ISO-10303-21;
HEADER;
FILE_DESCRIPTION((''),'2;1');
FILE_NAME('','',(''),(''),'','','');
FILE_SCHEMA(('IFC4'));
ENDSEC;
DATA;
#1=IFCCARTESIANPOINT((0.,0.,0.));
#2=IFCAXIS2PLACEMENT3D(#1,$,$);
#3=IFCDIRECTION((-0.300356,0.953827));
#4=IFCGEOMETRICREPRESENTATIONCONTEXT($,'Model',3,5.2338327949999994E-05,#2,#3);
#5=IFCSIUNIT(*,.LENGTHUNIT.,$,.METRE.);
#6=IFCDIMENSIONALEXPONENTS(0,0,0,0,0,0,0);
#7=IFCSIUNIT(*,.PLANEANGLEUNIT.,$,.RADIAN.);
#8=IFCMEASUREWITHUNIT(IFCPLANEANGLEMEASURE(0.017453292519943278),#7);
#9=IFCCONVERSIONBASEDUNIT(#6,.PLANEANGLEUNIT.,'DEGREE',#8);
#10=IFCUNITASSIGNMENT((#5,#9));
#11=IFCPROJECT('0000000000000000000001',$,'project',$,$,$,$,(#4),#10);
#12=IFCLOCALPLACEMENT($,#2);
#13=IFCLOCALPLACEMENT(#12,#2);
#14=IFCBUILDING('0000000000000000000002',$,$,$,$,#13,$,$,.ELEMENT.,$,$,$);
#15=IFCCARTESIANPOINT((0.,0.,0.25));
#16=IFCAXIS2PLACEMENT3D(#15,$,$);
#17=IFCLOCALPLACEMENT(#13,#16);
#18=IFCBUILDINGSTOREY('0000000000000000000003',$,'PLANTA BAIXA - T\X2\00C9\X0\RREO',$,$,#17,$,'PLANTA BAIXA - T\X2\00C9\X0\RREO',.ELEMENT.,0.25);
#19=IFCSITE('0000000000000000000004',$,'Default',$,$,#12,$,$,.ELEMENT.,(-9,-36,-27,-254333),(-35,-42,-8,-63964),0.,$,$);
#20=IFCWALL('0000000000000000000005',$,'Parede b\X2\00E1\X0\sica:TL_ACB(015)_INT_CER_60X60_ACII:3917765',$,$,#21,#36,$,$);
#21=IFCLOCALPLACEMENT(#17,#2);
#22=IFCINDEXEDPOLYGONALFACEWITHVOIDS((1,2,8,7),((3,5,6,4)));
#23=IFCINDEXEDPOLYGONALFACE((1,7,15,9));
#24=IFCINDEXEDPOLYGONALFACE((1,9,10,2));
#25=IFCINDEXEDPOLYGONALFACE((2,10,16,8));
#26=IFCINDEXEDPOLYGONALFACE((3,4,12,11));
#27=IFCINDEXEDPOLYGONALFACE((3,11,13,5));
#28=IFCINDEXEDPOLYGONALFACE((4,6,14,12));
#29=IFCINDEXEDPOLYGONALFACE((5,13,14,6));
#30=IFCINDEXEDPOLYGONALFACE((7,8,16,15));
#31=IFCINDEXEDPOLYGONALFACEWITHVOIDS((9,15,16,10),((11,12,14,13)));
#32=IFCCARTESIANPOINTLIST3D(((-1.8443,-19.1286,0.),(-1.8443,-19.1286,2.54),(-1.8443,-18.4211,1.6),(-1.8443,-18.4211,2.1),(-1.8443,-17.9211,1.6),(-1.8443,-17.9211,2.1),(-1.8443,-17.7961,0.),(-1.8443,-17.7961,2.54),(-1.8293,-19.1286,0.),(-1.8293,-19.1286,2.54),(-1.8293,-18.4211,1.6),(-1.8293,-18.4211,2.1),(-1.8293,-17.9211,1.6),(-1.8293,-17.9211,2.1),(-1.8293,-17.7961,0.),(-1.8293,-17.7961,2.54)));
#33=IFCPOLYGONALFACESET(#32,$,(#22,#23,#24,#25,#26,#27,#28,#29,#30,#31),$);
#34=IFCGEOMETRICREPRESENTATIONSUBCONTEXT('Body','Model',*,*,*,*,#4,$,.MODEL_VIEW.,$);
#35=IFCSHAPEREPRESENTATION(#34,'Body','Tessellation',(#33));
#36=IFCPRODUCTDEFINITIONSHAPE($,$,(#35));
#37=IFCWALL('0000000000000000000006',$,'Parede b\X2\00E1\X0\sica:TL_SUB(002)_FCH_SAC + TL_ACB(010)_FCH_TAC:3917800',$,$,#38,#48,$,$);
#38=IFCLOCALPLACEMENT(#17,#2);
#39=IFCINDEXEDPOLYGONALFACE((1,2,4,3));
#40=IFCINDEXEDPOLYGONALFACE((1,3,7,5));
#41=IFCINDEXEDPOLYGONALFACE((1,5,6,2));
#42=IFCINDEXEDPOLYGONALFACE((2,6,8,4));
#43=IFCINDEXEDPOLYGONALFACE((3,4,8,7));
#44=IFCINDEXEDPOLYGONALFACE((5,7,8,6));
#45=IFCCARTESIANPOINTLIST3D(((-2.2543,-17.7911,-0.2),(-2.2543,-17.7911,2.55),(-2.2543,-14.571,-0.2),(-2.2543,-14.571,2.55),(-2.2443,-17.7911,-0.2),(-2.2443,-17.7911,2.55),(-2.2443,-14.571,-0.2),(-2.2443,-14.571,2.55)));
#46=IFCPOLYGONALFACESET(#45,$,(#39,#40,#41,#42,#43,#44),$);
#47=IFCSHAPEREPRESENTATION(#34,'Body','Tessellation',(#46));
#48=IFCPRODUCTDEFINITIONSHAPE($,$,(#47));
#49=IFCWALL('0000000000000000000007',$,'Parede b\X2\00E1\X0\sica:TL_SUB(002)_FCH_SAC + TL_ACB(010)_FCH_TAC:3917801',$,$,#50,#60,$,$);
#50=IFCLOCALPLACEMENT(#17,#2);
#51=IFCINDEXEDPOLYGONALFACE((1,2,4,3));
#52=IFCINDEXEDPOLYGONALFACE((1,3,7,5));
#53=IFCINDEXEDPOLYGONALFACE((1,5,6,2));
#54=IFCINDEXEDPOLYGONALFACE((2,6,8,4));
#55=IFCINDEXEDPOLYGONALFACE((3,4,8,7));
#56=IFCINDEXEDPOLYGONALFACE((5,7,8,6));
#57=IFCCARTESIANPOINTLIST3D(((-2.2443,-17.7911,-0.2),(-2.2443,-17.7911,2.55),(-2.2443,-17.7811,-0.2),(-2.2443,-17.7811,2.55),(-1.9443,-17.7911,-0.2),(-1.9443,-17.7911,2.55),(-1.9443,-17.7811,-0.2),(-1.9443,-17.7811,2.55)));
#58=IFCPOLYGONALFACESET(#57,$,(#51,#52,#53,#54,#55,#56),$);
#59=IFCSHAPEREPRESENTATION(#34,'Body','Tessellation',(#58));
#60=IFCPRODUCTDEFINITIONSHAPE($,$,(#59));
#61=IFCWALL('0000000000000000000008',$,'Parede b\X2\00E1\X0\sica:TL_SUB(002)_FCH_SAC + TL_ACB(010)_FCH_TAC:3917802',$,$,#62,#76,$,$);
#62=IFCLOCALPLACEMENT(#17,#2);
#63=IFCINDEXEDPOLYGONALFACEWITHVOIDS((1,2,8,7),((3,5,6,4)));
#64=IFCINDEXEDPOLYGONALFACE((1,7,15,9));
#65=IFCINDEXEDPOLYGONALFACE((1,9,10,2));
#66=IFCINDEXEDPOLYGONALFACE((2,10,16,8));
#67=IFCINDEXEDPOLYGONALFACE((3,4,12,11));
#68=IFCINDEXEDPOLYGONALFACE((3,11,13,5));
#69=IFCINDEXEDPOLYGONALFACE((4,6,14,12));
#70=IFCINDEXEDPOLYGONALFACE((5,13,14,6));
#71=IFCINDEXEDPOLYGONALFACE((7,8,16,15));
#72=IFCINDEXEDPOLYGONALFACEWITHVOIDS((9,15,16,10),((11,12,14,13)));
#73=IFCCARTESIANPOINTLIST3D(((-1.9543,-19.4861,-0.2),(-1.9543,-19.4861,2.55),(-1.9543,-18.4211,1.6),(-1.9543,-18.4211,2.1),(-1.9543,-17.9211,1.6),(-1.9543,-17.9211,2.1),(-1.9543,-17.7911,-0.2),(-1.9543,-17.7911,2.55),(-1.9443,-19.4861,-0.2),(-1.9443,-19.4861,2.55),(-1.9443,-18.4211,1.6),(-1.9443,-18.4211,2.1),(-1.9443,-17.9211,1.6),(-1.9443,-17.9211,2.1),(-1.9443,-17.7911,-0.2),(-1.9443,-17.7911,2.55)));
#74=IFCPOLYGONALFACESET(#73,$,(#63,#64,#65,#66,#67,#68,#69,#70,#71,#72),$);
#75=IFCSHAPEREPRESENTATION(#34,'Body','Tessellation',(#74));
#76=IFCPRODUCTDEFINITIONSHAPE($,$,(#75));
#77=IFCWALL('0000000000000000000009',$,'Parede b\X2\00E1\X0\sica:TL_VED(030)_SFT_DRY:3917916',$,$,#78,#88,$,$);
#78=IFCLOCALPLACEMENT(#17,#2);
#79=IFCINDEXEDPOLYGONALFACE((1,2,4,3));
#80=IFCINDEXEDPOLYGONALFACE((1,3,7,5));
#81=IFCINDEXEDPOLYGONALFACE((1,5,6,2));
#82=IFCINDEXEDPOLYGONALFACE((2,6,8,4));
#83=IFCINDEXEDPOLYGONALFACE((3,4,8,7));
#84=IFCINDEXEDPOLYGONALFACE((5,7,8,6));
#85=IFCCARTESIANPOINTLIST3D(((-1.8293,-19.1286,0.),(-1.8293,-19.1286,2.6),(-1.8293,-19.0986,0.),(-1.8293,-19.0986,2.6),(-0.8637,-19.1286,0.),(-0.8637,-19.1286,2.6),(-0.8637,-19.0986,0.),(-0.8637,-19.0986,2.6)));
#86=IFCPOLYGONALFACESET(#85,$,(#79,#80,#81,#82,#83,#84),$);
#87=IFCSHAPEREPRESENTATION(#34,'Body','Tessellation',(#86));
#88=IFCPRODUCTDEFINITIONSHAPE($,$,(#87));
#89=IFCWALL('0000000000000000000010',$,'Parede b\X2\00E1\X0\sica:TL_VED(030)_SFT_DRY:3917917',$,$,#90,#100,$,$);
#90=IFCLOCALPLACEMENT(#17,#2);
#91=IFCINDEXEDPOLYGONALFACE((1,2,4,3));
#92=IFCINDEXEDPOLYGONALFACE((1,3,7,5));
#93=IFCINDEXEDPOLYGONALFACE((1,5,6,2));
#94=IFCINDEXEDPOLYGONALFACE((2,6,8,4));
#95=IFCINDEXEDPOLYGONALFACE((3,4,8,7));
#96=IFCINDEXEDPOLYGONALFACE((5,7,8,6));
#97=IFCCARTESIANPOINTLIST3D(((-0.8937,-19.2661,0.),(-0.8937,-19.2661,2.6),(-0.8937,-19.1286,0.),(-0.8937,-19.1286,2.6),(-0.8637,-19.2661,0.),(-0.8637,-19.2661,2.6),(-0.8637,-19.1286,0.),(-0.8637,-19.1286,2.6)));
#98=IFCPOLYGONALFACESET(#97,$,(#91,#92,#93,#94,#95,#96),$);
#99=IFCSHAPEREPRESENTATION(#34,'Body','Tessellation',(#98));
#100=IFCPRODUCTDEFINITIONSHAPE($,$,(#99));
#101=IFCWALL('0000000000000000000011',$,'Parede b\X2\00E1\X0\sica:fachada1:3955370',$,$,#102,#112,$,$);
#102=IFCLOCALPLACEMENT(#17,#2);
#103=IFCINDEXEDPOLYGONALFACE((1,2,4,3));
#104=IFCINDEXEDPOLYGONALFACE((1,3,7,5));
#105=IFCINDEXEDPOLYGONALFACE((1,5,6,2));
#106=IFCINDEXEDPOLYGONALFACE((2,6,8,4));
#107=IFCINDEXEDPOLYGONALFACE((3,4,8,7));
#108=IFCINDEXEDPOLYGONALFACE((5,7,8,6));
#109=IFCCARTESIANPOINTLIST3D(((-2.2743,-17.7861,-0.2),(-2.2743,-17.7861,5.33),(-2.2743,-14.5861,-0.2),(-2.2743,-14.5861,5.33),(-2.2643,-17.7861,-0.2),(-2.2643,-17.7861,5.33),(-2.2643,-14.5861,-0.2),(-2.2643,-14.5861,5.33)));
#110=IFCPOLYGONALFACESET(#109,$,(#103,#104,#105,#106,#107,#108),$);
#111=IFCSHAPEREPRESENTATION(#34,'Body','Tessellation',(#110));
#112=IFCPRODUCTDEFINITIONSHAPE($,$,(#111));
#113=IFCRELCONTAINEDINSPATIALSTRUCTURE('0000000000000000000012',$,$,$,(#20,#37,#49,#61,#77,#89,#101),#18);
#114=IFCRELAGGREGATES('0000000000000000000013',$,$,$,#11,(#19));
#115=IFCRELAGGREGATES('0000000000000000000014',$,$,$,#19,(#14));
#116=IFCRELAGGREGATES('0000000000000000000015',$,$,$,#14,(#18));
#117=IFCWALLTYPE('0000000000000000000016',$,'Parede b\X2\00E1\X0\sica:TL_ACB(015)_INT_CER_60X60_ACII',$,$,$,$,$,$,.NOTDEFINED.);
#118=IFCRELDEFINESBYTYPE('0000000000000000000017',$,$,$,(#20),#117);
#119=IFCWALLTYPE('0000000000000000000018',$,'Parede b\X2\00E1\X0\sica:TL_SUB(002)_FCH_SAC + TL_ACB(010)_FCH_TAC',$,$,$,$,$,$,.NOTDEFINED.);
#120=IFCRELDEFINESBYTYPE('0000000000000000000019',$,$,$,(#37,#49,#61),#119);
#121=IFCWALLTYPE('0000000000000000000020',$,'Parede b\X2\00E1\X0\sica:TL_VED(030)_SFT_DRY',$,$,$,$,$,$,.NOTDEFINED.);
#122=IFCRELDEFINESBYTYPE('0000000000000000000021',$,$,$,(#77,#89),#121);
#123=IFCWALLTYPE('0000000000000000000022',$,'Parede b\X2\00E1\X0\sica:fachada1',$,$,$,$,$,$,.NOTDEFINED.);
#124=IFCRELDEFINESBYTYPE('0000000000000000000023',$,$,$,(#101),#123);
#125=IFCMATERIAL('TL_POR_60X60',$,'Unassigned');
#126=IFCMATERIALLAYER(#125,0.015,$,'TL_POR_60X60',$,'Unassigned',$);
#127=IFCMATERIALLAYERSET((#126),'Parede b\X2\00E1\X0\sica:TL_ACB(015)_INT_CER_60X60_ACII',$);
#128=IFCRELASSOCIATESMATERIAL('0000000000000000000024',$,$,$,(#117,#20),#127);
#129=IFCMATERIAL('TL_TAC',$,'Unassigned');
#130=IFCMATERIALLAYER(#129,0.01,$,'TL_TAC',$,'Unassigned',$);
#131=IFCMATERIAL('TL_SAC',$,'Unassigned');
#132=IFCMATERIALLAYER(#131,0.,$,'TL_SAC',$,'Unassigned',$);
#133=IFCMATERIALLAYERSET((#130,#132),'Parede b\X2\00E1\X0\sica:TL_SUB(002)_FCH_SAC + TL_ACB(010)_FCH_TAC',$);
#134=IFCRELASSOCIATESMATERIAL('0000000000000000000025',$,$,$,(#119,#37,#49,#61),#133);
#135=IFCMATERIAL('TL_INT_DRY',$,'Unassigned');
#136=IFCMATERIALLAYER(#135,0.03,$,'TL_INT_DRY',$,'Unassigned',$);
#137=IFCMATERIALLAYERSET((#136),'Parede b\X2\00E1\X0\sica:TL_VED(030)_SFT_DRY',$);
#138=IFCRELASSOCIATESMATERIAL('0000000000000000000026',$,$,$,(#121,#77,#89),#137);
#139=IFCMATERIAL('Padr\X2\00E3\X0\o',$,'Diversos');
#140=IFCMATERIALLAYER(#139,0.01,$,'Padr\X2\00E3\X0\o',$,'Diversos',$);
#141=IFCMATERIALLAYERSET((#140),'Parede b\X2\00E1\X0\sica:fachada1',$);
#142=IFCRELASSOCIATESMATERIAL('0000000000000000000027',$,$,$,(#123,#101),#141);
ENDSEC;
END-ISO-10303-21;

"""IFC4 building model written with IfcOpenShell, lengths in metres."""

from ifc_helpers import new_model, entity, si_unit, converted_unit, direction, frame, frame_2d, origin, place, context, subcontext, project, spatial, rectangle, extrude, material, layer, layer_set, layer_usage, type_object, element, save


model = new_model("IFC4")

# Units and contexts
model_context = context("Model", 3, precision=5.2338327949999994e-05, world=origin(), true_north=direction((-0.300356, 0.953827)))
body_context = subcontext(model_context, "Body", "Model", "MODEL_VIEW")
ifc_project = project(units=[si_unit("LENGTHUNIT", "METRE"), converted_unit("PLANEANGLEUNIT", "DEGREE", entity("IfcPlaneAngleMeasure", 0.017453292519943278), si_unit("PLANEANGLEUNIT", "RADIAN"), dimensions=[0, 0, 0, 0, 0, 0, 0])], contexts=[model_context])

# Site, building, storey
site_placement = place(None, origin())
site = spatial("IfcSite", under=ifc_project, at=site_placement, Name="Default", CompositionType="ELEMENT", RefLatitude=(-9, -36, -27, -254333), RefLongitude=(-35, -42, -8, -63964), RefElevation=0.0)
building_placement = place(site_placement, origin())
building = spatial("IfcBuilding", under=site, at=building_placement, CompositionType="ELEMENT")
storey_placement = place(building_placement, frame((0.0, 0.0, 0.25)))
storey = spatial("IfcBuildingStorey", under=building, at=storey_placement, Name="PLANTA BAIXA - TÉRREO", LongName="PLANTA BAIXA - TÉRREO", CompositionType="ELEMENT", Elevation=0.25)

# Shared definitions
ifc_material_1 = material(Name="TL_POR_60X60", Category="Unassigned")

# Shared definitions
ifc_material_2 = material(Name="TL_SAC", Category="Unassigned")

# Shared definitions
ifc_layer_1 = layer(ifc_material_1, 0.015, Name="TL_POR_60X60", Category="Unassigned")
ifc_layer_set_1 = layer_set([ifc_layer_1], Name="Parede básica:TL_ACB(015)_INT_CER_60X60_ACII")
wall_type_1 = type_object("IfcWallType", Name="Parede básica:TL_ACB(015)_INT_CER_60X60_ACII", PredefinedType="NOTDEFINED", material=ifc_layer_set_1)

# Wall, opening
ifc_layer_usage_1 = layer_usage(ifc_layer_set_1, "AXIS2", "NEGATIVE", 0.0075)
wall_1_placement = place(storey_placement, frame((-1.8368, -17.7961, 0.0), z_axis=(0.0, 0.0, 1.0), x_axis=(0.0, -1.0, 0.0)))
wall_1 = element("IfcWall", 1, at=wall_1_placement, inside=storey, type_object=wall_type_1, material=ifc_layer_usage_1, Name="Parede básica:TL_ACB(015)_INT_CER_60X60_ACII:3917765", context=body_context, shape_type="SweptSolid", body=[
    extrude(rectangle(XDim=1.3325, YDim=0.015, at=frame_2d((0.6662, 0.0), x_axis=(-1.0, 0.0))), origin(), (0.0, 0.0, 1.0), 2.54),
])
opening_1_placement = place(wall_1_placement, frame((-17.7961, 1.8368, 1.6)))
element("IfcOpeningElement", 2, at=opening_1_placement, cuts=wall_1, PredefinedType="OPENING", context=body_context, shape_type="SweptSolid", body=[
    extrude(rectangle(XDim=0.5, YDim=0.5, at=frame_2d((0.0, 0.0), x_axis=(1.0, 0.0))), frame((18.1711, -3.4683, 0.25), z_axis=(0.0, 1.0, 0.0), x_axis=(0.0, 0.0, 1.0)), (0.0, 0.0, 1.0), 3.048),
])

# Walls
ifc_material_3 = material(Name="TL_TAC", Category="Unassigned")
ifc_layer_2 = layer(ifc_material_3, 0.01, Name="TL_TAC", Category="Unassigned")
ifc_layer_3 = layer(ifc_material_2, 0.0, Name="TL_SAC", Category="Unassigned")
ifc_layer_set_2 = layer_set([ifc_layer_2, ifc_layer_3], Name="Parede básica:TL_SUB(002)_FCH_SAC + TL_ACB(010)_FCH_TAC")
ifc_layer_usage_2 = layer_usage(ifc_layer_set_2, "AXIS2", "NEGATIVE", 0.005)
wall_type_2 = type_object("IfcWallType", Name="Parede básica:TL_SUB(002)_FCH_SAC + TL_ACB(010)_FCH_TAC", PredefinedType="NOTDEFINED", material=ifc_layer_set_2)
wall_2_placement = place(storey_placement, frame((-2.2493, -14.571, -0.2), z_axis=(0.0, 0.0, 1.0), x_axis=(0.0, -1.0, 0.0)))
element("IfcWall", 3, at=wall_2_placement, inside=storey, type_object=wall_type_2, material=ifc_layer_usage_2, Name="Parede básica:TL_SUB(002)_FCH_SAC + TL_ACB(010)_FCH_TAC:3917800", context=body_context, shape_type="SweptSolid", body=[
    extrude(rectangle(XDim=3.2201, YDim=0.01, at=frame_2d((1.6101, 0.0), x_axis=(-1.0, 0.0))), origin(), (0.0, 0.0, 1.0), 2.75),
])
ifc_layer_usage_3 = layer_usage(ifc_layer_set_2, "AXIS2", "NEGATIVE", 0.005)
wall_3_placement = place(storey_placement, frame((-2.2443, -17.7861, -0.2)))
element("IfcWall", 4, at=wall_3_placement, inside=storey, type_object=wall_type_2, material=ifc_layer_usage_3, Name="Parede básica:TL_SUB(002)_FCH_SAC + TL_ACB(010)_FCH_TAC:3917801", context=body_context, shape_type="SweptSolid", body=[
    extrude(rectangle(XDim=0.3, YDim=0.01, at=frame_2d((0.15, 0.0), x_axis=(-1.0, 0.0))), origin(), (0.0, 0.0, 1.0), 2.75),
])

# Wall, opening
ifc_layer_usage_4 = layer_usage(ifc_layer_set_2, "AXIS2", "NEGATIVE", 0.005)
wall_4_placement = place(storey_placement, frame((-1.9493, -17.7911, -0.2), z_axis=(0.0, 0.0, 1.0), x_axis=(0.0, -1.0, 0.0)))
wall_4 = element("IfcWall", 5, at=wall_4_placement, inside=storey, type_object=wall_type_2, material=ifc_layer_usage_4, Name="Parede básica:TL_SUB(002)_FCH_SAC + TL_ACB(010)_FCH_TAC:3917802", context=body_context, shape_type="SweptSolid", body=[
    extrude(rectangle(XDim=1.695, YDim=0.01, at=frame_2d((0.8475, 0.0), x_axis=(-1.0, 0.0))), origin(), (0.0, 0.0, 1.0), 2.75),
])
opening_2_placement = place(wall_4_placement, frame((-17.7911, 1.9493, 1.8)))
element("IfcOpeningElement", 6, at=opening_2_placement, cuts=wall_4, PredefinedType="OPENING", context=body_context, shape_type="SweptSolid", body=[
    extrude(rectangle(XDim=0.5, YDim=0.5, at=frame_2d((0.0, 0.0), x_axis=(1.0, 0.0))), frame((18.1711, -3.4683, 0.25), z_axis=(0.0, 1.0, 0.0), x_axis=(0.0, 0.0, 1.0)), (0.0, 0.0, 1.0), 3.048),
])

# Walls
ifc_material_4 = material(Name="TL_INT_DRY", Category="Unassigned")
ifc_layer_4 = layer(ifc_material_4, 0.03, Name="TL_INT_DRY", Category="Unassigned")
ifc_layer_set_3 = layer_set([ifc_layer_4], Name="Parede básica:TL_VED(030)_SFT_DRY")
ifc_layer_usage_5 = layer_usage(ifc_layer_set_3, "AXIS2", "NEGATIVE", 0.015)
wall_type_3 = type_object("IfcWallType", Name="Parede básica:TL_VED(030)_SFT_DRY", PredefinedType="NOTDEFINED", material=ifc_layer_set_3)
wall_5_placement = place(storey_placement, frame((-1.8293, -19.1136, 0.0)))
element("IfcWall", 7, at=wall_5_placement, inside=storey, type_object=wall_type_3, material=ifc_layer_usage_5, Name="Parede básica:TL_VED(030)_SFT_DRY:3917916", context=body_context, shape_type="SweptSolid", body=[
    extrude(rectangle(XDim=0.9655, YDim=0.03, at=frame_2d((0.4828, 0.0), x_axis=(-1.0, 0.0))), origin(), (0.0, 0.0, 1.0), 2.6),
])
ifc_layer_usage_6 = layer_usage(ifc_layer_set_3, "AXIS2", "NEGATIVE", 0.015)
wall_6_placement = place(storey_placement, frame((-0.8787, -19.1286, 0.0), z_axis=(0.0, 0.0, 1.0), x_axis=(0.0, -1.0, 0.0)))
element("IfcWall", 8, at=wall_6_placement, inside=storey, type_object=wall_type_3, material=ifc_layer_usage_6, Name="Parede básica:TL_VED(030)_SFT_DRY:3917917", context=body_context, shape_type="SweptSolid", body=[
    extrude(rectangle(XDim=0.1375, YDim=0.03, at=frame_2d((0.0688, 0.0), x_axis=(-1.0, 0.0))), origin(), (0.0, 0.0, 1.0), 2.6),
])
ifc_material_5 = material(Name="Padrão", Category="Diversos")
ifc_layer_5 = layer(ifc_material_5, 0.01, Name="Padrão", Category="Diversos")
ifc_layer_set_4 = layer_set([ifc_layer_5], Name="Parede básica:fachada1")
ifc_layer_usage_7 = layer_usage(ifc_layer_set_4, "AXIS2", "POSITIVE", -0.005)
wall_type_4 = type_object("IfcWallType", Name="Parede básica:fachada1", PredefinedType="NOTDEFINED", material=ifc_layer_set_4)
wall_7_placement = place(storey_placement, frame((-2.2693, -17.7861, -0.2), z_axis=(0.0, 0.0, 1.0), x_axis=(0.0, 1.0, 0.0)))
element("IfcWall", 9, at=wall_7_placement, inside=storey, type_object=wall_type_4, material=ifc_layer_usage_7, Name="Parede básica:fachada1:3955370", context=body_context, shape_type="SweptSolid", body=[
    extrude(rectangle(XDim=3.2, YDim=0.01, at=frame_2d((1.6, 0.0), x_axis=(-1.0, 0.0))), origin(), (0.0, 0.0, 1.0), 5.53),
])

save(model, "model.ifc")
